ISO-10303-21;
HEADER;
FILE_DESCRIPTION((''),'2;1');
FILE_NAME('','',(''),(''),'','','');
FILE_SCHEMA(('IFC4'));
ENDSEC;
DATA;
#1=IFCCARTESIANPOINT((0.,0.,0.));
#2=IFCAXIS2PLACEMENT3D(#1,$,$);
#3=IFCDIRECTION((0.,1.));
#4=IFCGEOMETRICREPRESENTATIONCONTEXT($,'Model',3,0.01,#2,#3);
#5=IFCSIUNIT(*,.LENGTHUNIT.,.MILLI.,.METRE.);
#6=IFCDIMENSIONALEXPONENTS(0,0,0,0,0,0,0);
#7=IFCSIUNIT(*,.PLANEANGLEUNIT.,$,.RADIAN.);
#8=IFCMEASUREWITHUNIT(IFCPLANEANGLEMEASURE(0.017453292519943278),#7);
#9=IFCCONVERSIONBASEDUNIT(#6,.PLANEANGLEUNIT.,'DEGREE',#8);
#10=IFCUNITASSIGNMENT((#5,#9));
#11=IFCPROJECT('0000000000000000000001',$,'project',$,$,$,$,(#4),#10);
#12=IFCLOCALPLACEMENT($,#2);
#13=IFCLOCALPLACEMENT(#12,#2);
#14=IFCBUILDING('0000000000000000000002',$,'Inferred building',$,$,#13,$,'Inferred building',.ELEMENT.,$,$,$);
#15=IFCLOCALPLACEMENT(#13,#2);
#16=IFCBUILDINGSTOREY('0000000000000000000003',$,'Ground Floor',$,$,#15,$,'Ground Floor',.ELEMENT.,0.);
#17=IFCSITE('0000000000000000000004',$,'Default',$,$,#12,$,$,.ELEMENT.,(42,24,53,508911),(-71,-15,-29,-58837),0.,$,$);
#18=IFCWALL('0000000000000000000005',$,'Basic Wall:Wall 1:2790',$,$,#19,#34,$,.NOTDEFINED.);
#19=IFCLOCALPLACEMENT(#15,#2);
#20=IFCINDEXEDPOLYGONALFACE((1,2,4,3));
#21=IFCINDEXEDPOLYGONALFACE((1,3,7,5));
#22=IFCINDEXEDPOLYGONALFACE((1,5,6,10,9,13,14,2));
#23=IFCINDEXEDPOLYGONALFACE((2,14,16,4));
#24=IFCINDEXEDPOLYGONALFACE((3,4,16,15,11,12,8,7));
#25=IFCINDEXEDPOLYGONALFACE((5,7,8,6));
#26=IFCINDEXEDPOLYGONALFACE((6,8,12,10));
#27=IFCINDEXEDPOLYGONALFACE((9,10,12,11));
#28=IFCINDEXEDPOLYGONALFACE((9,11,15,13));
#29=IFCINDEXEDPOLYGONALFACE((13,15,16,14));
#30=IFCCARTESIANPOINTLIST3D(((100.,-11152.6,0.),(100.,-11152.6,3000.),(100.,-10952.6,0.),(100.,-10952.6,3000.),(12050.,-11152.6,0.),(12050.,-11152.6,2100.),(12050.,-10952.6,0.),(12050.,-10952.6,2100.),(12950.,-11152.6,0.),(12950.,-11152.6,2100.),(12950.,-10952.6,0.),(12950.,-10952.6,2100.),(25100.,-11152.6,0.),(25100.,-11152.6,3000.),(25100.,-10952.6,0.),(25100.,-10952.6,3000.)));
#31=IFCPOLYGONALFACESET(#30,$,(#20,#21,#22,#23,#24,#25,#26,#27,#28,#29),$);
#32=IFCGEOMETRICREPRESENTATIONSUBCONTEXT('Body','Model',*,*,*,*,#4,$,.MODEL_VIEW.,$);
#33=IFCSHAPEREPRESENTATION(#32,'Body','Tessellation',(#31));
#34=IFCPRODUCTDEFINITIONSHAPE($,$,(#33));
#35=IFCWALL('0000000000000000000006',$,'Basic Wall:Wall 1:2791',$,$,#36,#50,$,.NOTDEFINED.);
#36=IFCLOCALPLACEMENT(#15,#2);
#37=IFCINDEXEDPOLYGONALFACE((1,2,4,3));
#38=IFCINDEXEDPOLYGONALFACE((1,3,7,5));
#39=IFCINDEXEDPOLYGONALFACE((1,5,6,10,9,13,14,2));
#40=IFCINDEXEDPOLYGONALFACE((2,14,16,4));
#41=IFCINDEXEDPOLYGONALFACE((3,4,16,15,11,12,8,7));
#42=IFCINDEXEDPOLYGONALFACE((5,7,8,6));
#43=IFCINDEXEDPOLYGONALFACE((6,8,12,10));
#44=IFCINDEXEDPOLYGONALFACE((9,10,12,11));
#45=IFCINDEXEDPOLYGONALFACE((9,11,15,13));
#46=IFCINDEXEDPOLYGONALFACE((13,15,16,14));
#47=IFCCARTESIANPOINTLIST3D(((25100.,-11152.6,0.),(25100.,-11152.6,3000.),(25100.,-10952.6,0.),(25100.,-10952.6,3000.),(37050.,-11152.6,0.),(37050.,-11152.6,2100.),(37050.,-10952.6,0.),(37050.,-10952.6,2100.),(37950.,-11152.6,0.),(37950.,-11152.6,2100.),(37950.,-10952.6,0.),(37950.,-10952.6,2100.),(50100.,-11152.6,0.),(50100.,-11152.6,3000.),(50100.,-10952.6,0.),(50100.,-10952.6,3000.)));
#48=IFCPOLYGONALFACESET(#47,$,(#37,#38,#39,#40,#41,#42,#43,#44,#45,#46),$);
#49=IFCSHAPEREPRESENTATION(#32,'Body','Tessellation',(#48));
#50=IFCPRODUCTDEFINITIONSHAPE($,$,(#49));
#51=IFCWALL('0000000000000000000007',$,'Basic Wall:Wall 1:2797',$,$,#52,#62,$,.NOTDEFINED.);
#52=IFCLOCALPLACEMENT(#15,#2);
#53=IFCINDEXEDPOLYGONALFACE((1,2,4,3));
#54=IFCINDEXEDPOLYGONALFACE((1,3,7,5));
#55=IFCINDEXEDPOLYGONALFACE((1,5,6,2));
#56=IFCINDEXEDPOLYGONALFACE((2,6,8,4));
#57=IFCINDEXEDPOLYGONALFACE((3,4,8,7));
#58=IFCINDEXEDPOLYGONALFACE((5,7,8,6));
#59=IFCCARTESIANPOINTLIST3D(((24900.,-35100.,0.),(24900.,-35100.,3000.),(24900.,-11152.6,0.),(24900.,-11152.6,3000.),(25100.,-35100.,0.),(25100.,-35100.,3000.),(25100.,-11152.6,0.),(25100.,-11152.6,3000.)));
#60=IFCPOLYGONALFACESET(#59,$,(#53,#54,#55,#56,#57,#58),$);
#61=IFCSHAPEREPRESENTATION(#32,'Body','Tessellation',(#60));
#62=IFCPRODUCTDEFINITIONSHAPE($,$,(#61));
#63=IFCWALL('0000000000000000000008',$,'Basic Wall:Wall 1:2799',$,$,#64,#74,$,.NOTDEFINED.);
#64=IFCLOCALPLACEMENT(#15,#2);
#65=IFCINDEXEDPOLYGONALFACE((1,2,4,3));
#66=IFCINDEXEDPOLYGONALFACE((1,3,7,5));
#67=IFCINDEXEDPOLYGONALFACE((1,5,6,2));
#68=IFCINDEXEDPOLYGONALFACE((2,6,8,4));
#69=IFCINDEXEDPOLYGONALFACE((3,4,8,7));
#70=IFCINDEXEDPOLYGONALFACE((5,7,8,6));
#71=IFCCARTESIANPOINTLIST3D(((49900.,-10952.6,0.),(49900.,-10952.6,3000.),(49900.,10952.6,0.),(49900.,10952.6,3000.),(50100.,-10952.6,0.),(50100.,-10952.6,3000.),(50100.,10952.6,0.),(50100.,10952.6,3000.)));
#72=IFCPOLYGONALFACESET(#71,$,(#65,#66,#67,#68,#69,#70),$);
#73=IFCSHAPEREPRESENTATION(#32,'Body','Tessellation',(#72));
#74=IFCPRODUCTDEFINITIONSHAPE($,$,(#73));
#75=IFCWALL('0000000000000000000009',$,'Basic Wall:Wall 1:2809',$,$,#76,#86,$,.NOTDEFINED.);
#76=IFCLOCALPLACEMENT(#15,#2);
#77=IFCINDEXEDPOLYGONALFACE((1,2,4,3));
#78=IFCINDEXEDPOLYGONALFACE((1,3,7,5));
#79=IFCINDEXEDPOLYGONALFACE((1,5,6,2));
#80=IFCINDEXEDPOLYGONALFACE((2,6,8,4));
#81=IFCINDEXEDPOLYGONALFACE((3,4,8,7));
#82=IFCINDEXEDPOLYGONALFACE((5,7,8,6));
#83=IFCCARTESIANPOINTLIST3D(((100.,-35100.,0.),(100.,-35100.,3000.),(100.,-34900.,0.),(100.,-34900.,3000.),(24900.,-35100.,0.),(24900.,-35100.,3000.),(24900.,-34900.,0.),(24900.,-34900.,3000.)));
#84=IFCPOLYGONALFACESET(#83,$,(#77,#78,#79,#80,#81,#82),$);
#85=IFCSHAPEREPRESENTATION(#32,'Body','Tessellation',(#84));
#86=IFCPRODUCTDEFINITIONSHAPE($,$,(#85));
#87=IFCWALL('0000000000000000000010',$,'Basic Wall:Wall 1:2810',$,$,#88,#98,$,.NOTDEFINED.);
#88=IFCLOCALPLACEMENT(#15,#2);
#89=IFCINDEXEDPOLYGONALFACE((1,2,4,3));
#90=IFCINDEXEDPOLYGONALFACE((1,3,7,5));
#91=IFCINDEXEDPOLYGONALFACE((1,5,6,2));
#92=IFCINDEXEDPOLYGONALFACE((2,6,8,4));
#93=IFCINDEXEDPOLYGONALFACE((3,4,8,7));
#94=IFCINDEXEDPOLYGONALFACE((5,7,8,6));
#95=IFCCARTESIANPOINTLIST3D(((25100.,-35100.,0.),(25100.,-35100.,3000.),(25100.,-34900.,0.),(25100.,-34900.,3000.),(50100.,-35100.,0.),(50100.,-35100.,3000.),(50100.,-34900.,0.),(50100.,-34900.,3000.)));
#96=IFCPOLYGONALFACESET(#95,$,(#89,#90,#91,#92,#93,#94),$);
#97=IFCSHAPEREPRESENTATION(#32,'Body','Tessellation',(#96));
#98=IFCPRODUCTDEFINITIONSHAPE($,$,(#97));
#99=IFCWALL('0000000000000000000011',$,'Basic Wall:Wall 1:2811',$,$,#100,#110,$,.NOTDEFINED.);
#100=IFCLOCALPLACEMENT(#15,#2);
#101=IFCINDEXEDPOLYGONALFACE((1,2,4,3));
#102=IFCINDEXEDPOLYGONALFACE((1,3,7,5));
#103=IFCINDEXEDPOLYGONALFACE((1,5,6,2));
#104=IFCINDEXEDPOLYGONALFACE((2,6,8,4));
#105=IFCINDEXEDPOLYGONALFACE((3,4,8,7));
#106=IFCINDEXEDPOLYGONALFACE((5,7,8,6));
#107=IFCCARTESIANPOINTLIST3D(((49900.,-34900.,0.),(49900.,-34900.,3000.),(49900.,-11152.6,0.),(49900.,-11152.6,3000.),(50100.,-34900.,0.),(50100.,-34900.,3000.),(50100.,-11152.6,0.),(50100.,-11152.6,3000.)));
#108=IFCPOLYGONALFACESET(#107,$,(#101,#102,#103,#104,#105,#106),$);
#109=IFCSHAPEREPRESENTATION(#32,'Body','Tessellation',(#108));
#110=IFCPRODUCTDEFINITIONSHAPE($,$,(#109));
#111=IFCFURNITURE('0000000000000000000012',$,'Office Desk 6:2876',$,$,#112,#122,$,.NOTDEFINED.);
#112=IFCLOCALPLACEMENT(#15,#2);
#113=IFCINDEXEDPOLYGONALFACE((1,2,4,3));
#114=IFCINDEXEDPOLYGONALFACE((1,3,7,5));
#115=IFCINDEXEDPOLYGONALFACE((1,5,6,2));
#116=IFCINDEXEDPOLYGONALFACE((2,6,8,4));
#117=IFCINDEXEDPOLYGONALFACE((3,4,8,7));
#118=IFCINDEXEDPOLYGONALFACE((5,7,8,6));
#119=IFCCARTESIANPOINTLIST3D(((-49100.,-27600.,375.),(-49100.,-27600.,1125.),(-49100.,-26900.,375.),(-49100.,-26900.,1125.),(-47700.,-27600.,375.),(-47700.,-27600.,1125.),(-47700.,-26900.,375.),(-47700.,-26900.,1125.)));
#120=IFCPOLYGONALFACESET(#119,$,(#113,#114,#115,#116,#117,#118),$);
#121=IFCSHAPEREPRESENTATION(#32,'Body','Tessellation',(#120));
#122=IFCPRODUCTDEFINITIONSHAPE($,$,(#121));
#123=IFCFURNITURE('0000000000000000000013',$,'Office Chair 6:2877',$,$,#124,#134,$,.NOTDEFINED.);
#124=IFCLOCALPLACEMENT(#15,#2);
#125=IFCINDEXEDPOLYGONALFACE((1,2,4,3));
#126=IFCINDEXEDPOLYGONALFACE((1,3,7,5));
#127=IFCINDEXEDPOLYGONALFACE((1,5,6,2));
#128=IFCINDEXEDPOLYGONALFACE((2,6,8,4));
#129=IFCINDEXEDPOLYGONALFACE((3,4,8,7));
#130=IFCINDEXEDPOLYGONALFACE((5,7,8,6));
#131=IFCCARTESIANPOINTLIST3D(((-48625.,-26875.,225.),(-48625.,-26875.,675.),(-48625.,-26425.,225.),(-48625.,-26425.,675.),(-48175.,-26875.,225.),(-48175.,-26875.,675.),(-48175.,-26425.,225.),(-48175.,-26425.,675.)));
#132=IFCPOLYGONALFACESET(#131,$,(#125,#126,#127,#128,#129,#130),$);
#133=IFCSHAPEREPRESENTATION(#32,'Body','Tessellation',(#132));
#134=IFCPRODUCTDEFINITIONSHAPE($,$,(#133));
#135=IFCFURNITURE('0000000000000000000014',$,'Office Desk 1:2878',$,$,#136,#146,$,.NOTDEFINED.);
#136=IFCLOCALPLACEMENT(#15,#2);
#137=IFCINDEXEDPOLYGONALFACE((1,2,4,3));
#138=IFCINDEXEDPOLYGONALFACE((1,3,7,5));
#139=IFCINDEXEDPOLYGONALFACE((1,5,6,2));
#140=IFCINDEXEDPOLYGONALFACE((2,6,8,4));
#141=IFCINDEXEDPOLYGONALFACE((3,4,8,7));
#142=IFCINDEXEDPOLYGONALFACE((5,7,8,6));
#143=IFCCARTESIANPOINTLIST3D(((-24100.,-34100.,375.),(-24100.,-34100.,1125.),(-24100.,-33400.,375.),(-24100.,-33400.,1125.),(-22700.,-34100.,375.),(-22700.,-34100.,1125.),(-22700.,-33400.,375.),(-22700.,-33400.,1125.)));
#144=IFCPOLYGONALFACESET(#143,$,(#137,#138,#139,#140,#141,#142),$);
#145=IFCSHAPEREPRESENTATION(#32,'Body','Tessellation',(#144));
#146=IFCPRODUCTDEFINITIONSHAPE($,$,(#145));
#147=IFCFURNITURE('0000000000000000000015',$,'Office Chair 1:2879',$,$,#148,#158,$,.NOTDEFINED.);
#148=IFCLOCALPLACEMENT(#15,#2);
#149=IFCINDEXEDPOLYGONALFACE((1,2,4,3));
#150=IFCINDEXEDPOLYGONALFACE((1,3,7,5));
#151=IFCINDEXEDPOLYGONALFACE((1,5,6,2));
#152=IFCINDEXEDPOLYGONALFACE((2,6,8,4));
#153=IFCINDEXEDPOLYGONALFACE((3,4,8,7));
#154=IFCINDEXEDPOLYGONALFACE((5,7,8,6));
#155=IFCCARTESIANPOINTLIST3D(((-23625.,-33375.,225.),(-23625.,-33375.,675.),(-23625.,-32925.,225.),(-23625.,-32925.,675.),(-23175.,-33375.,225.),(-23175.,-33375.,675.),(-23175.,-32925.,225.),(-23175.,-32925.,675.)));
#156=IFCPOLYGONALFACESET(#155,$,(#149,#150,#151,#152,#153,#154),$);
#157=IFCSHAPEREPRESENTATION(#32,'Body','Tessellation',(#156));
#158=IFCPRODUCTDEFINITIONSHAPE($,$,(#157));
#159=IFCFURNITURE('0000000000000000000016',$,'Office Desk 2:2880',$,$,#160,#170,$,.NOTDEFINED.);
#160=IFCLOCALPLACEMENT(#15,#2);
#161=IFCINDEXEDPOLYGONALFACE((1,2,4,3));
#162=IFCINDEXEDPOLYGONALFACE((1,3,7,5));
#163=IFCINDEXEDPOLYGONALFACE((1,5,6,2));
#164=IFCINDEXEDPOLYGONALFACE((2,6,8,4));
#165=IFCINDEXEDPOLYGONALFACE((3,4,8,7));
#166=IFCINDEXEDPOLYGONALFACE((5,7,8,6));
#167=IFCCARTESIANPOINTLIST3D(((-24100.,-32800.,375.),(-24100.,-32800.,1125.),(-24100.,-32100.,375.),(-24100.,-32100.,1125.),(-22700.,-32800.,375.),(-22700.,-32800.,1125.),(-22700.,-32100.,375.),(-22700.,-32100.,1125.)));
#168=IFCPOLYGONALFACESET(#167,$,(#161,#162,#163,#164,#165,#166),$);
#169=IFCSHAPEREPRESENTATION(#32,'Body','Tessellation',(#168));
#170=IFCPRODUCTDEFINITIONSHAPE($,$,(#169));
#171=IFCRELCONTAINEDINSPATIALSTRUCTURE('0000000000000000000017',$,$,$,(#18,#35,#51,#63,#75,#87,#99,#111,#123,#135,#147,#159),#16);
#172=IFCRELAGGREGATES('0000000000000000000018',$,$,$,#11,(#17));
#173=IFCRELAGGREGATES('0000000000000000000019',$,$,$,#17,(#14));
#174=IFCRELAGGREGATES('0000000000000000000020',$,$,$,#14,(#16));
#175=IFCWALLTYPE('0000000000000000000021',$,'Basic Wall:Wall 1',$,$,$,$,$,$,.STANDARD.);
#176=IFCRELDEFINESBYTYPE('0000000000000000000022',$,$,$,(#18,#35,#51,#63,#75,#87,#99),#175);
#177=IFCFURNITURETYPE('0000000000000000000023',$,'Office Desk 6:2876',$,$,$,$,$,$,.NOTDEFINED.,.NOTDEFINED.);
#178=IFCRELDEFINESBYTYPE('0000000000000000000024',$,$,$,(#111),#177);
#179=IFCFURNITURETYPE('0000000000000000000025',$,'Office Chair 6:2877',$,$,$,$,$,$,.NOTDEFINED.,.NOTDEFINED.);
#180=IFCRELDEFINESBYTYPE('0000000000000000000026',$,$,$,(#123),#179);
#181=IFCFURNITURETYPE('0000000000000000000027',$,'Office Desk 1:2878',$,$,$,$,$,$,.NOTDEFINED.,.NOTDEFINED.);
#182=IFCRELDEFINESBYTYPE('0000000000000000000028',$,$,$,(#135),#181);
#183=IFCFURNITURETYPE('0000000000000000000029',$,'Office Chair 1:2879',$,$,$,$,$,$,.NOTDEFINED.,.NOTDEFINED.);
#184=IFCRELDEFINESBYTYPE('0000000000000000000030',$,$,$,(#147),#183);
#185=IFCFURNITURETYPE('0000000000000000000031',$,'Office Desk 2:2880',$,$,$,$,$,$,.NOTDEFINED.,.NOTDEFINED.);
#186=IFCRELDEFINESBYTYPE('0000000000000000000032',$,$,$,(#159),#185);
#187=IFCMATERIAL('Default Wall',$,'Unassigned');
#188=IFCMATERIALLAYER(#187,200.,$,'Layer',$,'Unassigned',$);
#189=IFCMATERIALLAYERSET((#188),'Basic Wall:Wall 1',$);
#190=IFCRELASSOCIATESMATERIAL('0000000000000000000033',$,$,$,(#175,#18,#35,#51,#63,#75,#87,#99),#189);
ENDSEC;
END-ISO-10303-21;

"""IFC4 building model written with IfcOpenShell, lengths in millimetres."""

from ifc_helpers import new_model, entity, si_unit, converted_unit, direction, frame, frame_2d, origin, origin_2d_with_axis, place, context, subcontext, project, spatial, rectangle, extrude, material, layer, layer_set, layer_usage, type_object, element, save


model = new_model("IFC4")

# Units and contexts
model_context = context("Model", 3, precision=0.01, world=origin(), true_north=direction((0.0, 1.0)))
body_context = subcontext(model_context, "Body", "Model", "MODEL_VIEW")
ifc_project = project(units=[si_unit("LENGTHUNIT", "METRE", prefix="MILLI"), converted_unit("PLANEANGLEUNIT", "DEGREE", entity("IfcPlaneAngleMeasure", 0.017453292519943278), si_unit("PLANEANGLEUNIT", "RADIAN"), dimensions=[0, 0, 0, 0, 0, 0, 0])], contexts=[model_context])

# Site, building, storey
site_placement = place(None, origin())
site = spatial("IfcSite", under=ifc_project, at=site_placement, Name="Default", CompositionType="ELEMENT", RefLatitude=(42, 24, 53, 508911), RefLongitude=(-71, -15, -29, -58837), RefElevation=0.0)
building_placement = place(site_placement, origin())
building = spatial("IfcBuilding", under=site, at=building_placement, Name="Inferred building", LongName="Inferred building", CompositionType="ELEMENT")
storey_placement = place(building_placement, origin())
storey = spatial("IfcBuildingStorey", under=building, at=storey_placement, Name="Ground Floor", LongName="Ground Floor", CompositionType="ELEMENT", Elevation=0.0)

# Walls, openings
ifc_material = material(Name="Default Wall", Category="Unassigned")
ifc_layer = layer(ifc_material, 200.0, Name="Layer", Category="Unassigned")
ifc_layer_set = layer_set([ifc_layer], Name="Basic Wall:Wall 1")
ifc_layer_usage_1 = layer_usage(ifc_layer_set, "AXIS2", "NEGATIVE", 100.0)
wall_type = type_object("IfcWallType", Name="Basic Wall:Wall 1", PredefinedType="STANDARD", material=ifc_layer_set)
wall_1_placement = place(storey_placement, frame((100.0, -11052.6, 0.0)))
wall_1 = element("IfcWall", 1, at=wall_1_placement, inside=storey, type_object=wall_type, material=ifc_layer_usage_1, Name="Basic Wall:Wall 1:2790", PredefinedType="NOTDEFINED", context=body_context, shape_type="SweptSolid", body=[
    extrude(rectangle(XDim=25000.0, YDim=200.0, at=frame_2d((12500.0, 0.0), x_axis=(-1.0, 0.0))), origin(), (0.0, 0.0, 1.0), 3000.0),
])
opening_1_placement = place(wall_1_placement, origin())
element("IfcOpeningElement", 2, at=opening_1_placement, cuts=wall_1, PredefinedType="OPENING", context=body_context, shape_type="SweptSolid", body=[
    extrude(rectangle(XDim=2100.0, YDim=900.0, at=origin_2d_with_axis()), frame((12400.0, -100.0, 1050.0), z_axis=(0.0, 1.0, 0.0), x_axis=(0.0, 0.0, -1.0)), (0.0, 0.0, 1.0), 200.0),
])
ifc_layer_usage_2 = layer_usage(ifc_layer_set, "AXIS2", "NEGATIVE", 100.0)
wall_2_placement = place(storey_placement, frame((25100.0, -11052.6, 0.0)))
wall_2 = element("IfcWall", 3, at=wall_2_placement, inside=storey, type_object=wall_type, material=ifc_layer_usage_2, Name="Basic Wall:Wall 1:2791", PredefinedType="NOTDEFINED", context=body_context, shape_type="SweptSolid", body=[
    extrude(rectangle(XDim=25000.0, YDim=200.0, at=frame_2d((12500.0, 0.0), x_axis=(-1.0, 0.0))), origin(), (0.0, 0.0, 1.0), 3000.0),
])
opening_2_placement = place(wall_2_placement, origin())
element("IfcOpeningElement", 4, at=opening_2_placement, cuts=wall_2, PredefinedType="OPENING", context=body_context, shape_type="SweptSolid", body=[
    extrude(rectangle(XDim=2100.0, YDim=900.0, at=frame_2d((0.0, 0.0), x_axis=(1.0, 0.0))), frame((12400.0, -100.0, 1050.0), z_axis=(0.0, 1.0, 0.0), x_axis=(0.0, 0.0, -1.0)), (0.0, 0.0, 1.0), 200.0),
])

# Walls
ifc_layer_usage_3 = layer_usage(ifc_layer_set, "AXIS2", "NEGATIVE", 100.0)
wall_3_placement = place(storey_placement, frame((25000.0, -35100.0, 0.0), z_axis=(0.0, 0.0, 1.0), x_axis=(0.0, 1.0, 0.0)))
element("IfcWall", 5, at=wall_3_placement, inside=storey, type_object=wall_type, material=ifc_layer_usage_3, Name="Basic Wall:Wall 1:2797", PredefinedType="NOTDEFINED", context=body_context, shape_type="SweptSolid", body=[
    extrude(rectangle(XDim=23947.4, YDim=200.0, at=frame_2d((11973.7, 0.0), x_axis=(-1.0, 0.0))), origin(), (0.0, 0.0, 1.0), 3000.0),
])
ifc_layer_usage_4 = layer_usage(ifc_layer_set, "AXIS2", "NEGATIVE", 100.0)
wall_4_placement = place(storey_placement, frame((50000.0, -10952.6, 0.0), z_axis=(0.0, 0.0, 1.0), x_axis=(0.0, 1.0, 0.0)))
element("IfcWall", 6, at=wall_4_placement, inside=storey, type_object=wall_type, material=ifc_layer_usage_4, Name="Basic Wall:Wall 1:2799", PredefinedType="NOTDEFINED", context=body_context, shape_type="SweptSolid", body=[
    extrude(rectangle(XDim=21905.3, YDim=200.0, at=frame_2d((10952.6, 0.0), x_axis=(-1.0, 0.0))), origin(), (0.0, 0.0, 1.0), 3000.0),
])
ifc_layer_usage_5 = layer_usage(ifc_layer_set, "AXIS2", "NEGATIVE", 100.0)
wall_5_placement = place(storey_placement, frame((100.0, -35000.0, 0.0)))
element("IfcWall", 7, at=wall_5_placement, inside=storey, type_object=wall_type, material=ifc_layer_usage_5, Name="Basic Wall:Wall 1:2809", PredefinedType="NOTDEFINED", context=body_context, shape_type="SweptSolid", body=[
    extrude(rectangle(XDim=24800.0, YDim=200.0, at=frame_2d((12400.0, 0.0), x_axis=(-1.0, 0.0))), origin(), (0.0, 0.0, 1.0), 3000.0),
])
ifc_layer_usage_6 = layer_usage(ifc_layer_set, "AXIS2", "NEGATIVE", 100.0)
wall_6_placement = place(storey_placement, frame((25100.0, -35000.0, 0.0)))
element("IfcWall", 8, at=wall_6_placement, inside=storey, type_object=wall_type, material=ifc_layer_usage_6, Name="Basic Wall:Wall 1:2810", PredefinedType="NOTDEFINED", context=body_context, shape_type="SweptSolid", body=[
    extrude(rectangle(XDim=25000.0, YDim=200.0, at=frame_2d((12500.0, 0.0), x_axis=(-1.0, 0.0))), origin(), (0.0, 0.0, 1.0), 3000.0),
])
ifc_layer_usage_7 = layer_usage(ifc_layer_set, "AXIS2", "NEGATIVE", 100.0)
wall_7_placement = place(storey_placement, frame((50000.0, -34900.0, 0.0), z_axis=(0.0, 0.0, 1.0), x_axis=(0.0, 1.0, 0.0)))
element("IfcWall", 9, at=wall_7_placement, inside=storey, type_object=wall_type, material=ifc_layer_usage_7, Name="Basic Wall:Wall 1:2811", PredefinedType="NOTDEFINED", context=body_context, shape_type="SweptSolid", body=[
    extrude(rectangle(XDim=23747.4, YDim=200.0, at=frame_2d((11873.7, 0.0), x_axis=(-1.0, 0.0))), origin(), (0.0, 0.0, 1.0), 3000.0),
])

# Furniture
furniture_type_1 = type_object("IfcFurnitureType", Name="Office Desk 6:2876", PredefinedType="NOTDEFINED")
furniture_1_placement = place(storey_placement, origin())
element("IfcFurniture", 10, at=furniture_1_placement, inside=storey, type_object=furniture_type_1, Name="Office Desk 6:2876", PredefinedType="NOTDEFINED", context=body_context, shape_type="SweptSolid", body=[
    extrude(rectangle(XDim=1400.0, YDim=700.0, at=origin_2d_with_axis()), frame((-48400.0, -27250.0, 375.0)), (0.0, 0.0, 1.0), 750.0),
])
furniture_type_2 = type_object("IfcFurnitureType", Name="Office Chair 6:2877", PredefinedType="NOTDEFINED")
furniture_2_placement = place(storey_placement, origin())
element("IfcFurniture", 11, at=furniture_2_placement, inside=storey, type_object=furniture_type_2, Name="Office Chair 6:2877", PredefinedType="NOTDEFINED", context=body_context, shape_type="SweptSolid", body=[
    extrude(rectangle(XDim=450.0, YDim=450.0, at=origin_2d_with_axis()), frame((-48400.0, -26650.0, 225.0)), (0.0, 0.0, 1.0), 450.0),
])
furniture_type_3 = type_object("IfcFurnitureType", Name="Office Desk 1:2878", PredefinedType="NOTDEFINED")
furniture_3_placement = place(storey_placement, origin())
element("IfcFurniture", 12, at=furniture_3_placement, inside=storey, type_object=furniture_type_3, Name="Office Desk 1:2878", PredefinedType="NOTDEFINED", context=body_context, shape_type="SweptSolid", body=[
    extrude(rectangle(XDim=1400.0, YDim=700.0, at=origin_2d_with_axis()), frame((-23400.0, -33750.0, 375.0)), (0.0, 0.0, 1.0), 750.0),
])
furniture_type_4 = type_object("IfcFurnitureType", Name="Office Chair 1:2879", PredefinedType="NOTDEFINED")
furniture_4_placement = place(storey_placement, origin())
element("IfcFurniture", 13, at=furniture_4_placement, inside=storey, type_object=furniture_type_4, Name="Office Chair 1:2879", PredefinedType="NOTDEFINED", context=body_context, shape_type="SweptSolid", body=[
    extrude(rectangle(XDim=450.0, YDim=450.0, at=origin_2d_with_axis()), frame((-23400.0, -33150.0, 225.0)), (0.0, 0.0, 1.0), 450.0),
])
furniture_type_5 = type_object("IfcFurnitureType", Name="Office Desk 2:2880", PredefinedType="NOTDEFINED")
furniture_5_placement = place(storey_placement, origin())
element("IfcFurniture", 14, at=furniture_5_placement, inside=storey, type_object=furniture_type_5, Name="Office Desk 2:2880", PredefinedType="NOTDEFINED", context=body_context, shape_type="SweptSolid", body=[
    extrude(rectangle(XDim=1400.0, YDim=700.0, at=origin_2d_with_axis()), frame((-23400.0, -32450.0, 375.0)), (0.0, 0.0, 1.0), 750.0),
])

save(model, "model.ifc")
